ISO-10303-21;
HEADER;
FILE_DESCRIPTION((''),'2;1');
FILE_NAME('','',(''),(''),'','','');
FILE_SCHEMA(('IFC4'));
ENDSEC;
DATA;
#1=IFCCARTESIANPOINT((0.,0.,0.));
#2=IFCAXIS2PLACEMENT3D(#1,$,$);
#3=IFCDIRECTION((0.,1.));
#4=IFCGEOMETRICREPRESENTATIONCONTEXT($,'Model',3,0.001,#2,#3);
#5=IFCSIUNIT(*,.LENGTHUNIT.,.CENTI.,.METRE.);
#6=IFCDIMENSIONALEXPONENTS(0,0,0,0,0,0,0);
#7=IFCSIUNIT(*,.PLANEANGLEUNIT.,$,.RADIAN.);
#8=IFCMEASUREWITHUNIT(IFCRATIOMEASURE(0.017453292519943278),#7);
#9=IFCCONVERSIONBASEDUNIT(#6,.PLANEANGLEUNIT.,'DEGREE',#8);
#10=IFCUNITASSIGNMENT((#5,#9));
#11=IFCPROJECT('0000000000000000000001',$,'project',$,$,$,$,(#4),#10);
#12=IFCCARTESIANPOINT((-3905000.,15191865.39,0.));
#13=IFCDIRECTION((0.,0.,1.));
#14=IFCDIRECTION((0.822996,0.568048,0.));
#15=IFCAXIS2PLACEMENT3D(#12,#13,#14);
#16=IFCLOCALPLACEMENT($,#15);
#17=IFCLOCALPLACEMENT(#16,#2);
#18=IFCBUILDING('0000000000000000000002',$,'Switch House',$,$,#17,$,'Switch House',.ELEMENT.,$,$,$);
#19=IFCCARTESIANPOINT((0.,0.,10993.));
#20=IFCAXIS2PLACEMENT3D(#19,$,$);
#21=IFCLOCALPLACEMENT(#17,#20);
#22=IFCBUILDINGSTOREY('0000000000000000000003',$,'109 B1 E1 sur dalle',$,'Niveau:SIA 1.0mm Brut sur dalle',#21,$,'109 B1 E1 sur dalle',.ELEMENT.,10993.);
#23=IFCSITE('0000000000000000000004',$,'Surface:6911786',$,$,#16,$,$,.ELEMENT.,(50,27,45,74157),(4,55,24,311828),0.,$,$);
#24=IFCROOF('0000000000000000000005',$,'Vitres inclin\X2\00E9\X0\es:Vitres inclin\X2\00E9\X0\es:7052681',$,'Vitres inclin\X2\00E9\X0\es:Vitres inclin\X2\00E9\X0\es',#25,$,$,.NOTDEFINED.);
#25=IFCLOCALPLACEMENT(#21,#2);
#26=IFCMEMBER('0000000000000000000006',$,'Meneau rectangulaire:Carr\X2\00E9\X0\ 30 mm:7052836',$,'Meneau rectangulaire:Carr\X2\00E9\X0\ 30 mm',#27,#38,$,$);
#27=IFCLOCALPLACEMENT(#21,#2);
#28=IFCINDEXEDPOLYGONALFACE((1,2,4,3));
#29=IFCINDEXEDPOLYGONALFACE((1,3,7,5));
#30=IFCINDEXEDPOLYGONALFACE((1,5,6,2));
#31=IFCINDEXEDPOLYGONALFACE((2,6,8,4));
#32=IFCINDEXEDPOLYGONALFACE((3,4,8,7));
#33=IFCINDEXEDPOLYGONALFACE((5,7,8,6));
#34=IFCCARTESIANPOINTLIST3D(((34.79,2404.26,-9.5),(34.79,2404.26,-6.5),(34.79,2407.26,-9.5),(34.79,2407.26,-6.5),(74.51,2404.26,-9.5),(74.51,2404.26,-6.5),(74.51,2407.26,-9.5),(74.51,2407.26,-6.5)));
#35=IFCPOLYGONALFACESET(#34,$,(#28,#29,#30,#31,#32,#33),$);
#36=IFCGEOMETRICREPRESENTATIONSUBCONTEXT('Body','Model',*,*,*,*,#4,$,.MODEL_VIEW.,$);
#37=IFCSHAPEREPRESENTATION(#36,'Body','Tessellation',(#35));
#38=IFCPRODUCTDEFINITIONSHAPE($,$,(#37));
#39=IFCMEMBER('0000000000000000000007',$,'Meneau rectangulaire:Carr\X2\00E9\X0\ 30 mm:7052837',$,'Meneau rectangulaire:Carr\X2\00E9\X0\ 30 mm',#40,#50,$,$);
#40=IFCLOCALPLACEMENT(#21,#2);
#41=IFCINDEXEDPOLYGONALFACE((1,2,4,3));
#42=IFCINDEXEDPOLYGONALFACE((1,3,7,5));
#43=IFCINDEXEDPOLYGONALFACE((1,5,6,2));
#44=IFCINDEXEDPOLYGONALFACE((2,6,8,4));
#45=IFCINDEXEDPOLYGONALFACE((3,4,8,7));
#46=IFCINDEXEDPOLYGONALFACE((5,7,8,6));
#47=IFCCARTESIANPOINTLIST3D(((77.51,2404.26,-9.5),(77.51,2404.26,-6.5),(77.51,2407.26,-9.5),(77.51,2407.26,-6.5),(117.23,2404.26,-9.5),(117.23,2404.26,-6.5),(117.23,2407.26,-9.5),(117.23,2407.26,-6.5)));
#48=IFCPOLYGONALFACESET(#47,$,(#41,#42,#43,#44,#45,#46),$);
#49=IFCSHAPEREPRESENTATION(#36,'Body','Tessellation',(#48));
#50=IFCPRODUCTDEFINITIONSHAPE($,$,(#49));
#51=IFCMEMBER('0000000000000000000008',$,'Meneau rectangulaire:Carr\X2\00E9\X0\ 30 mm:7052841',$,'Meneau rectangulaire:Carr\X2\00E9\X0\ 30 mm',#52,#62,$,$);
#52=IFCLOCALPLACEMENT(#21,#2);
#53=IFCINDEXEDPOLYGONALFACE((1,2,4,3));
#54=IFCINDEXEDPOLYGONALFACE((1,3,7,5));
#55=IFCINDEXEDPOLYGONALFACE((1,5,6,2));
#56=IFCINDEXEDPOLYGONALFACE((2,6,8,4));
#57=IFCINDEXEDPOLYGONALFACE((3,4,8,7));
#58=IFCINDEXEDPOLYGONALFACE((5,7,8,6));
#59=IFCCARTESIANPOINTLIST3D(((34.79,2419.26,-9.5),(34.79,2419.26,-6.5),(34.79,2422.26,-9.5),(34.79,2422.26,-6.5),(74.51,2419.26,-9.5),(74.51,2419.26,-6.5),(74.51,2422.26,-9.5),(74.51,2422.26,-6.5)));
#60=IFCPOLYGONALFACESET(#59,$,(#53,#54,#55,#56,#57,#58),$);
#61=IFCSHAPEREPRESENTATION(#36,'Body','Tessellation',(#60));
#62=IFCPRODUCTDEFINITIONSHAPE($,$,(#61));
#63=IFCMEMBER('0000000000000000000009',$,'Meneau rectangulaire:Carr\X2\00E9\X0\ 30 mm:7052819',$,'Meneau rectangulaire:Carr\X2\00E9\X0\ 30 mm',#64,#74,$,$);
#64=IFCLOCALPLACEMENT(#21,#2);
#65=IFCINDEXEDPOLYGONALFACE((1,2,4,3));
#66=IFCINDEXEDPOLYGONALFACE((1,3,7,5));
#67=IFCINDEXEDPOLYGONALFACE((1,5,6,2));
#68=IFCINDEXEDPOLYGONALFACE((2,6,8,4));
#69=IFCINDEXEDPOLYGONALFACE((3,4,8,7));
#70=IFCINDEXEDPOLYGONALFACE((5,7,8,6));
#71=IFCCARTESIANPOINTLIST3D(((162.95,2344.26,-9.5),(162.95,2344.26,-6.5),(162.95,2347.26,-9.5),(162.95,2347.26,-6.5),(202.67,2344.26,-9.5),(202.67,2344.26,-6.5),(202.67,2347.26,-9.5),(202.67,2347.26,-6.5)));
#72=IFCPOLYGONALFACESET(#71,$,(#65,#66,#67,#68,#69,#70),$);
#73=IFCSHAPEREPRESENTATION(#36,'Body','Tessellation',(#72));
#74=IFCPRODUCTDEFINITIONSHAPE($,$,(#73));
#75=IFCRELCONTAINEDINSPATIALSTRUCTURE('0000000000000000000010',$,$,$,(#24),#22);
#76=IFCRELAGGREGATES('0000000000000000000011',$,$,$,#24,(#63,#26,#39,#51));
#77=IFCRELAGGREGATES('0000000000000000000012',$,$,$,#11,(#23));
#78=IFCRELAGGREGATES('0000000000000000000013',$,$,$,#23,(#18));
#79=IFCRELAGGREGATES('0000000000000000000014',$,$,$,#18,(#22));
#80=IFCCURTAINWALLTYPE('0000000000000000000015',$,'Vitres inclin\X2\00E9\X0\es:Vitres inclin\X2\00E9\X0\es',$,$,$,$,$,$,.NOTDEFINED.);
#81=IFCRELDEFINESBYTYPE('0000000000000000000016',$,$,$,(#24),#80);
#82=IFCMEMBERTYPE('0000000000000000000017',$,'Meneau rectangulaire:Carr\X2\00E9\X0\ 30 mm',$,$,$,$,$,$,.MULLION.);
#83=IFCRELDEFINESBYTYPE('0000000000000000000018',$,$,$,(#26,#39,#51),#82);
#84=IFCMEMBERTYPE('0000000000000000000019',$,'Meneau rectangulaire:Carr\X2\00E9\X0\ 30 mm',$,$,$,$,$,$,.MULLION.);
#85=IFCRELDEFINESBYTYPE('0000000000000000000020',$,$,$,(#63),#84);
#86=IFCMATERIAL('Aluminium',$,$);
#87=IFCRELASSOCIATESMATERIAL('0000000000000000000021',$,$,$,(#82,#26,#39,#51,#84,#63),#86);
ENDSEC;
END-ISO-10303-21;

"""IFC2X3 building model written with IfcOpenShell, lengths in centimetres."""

from ifc_helpers import new_model, entity, si_unit, converted_unit, direction, frame, origin, origin_2d_with_axis, place, context, subcontext, project, spatial, rectangle, extrude, source, transform, mapped, material, type_object, type_shapes, element, aggregate, save


model = new_model("IFC2X3")

# Units and contexts
model_context = context("Model", 3, precision=0.001, world=origin(), true_north=direction((0.0, 1.0)))
body_context = subcontext(model_context, "Body", "Model", "MODEL_VIEW")
ifc_project = project(units=[si_unit("LENGTHUNIT", "METRE", prefix="CENTI"), converted_unit("PLANEANGLEUNIT", "DEGREE", entity("IfcRatioMeasure", 0.017453292519943278), si_unit("PLANEANGLEUNIT", "RADIAN"), dimensions=[0, 0, 0, 0, 0, 0, 0])], contexts=[model_context])

# Site, building, storey
site_placement = place(None, frame((-3905000.0, 15191865.39, 0.0), z_axis=(0.0, 0.0, 1.0), x_axis=(0.822996, 0.568048, 0.0)))
site = spatial("IfcSite", under=ifc_project, at=site_placement, Name="Surface:6911786", CompositionType="ELEMENT", RefLatitude=(50, 27, 45, 74157), RefLongitude=(4, 55, 24, 311828), RefElevation=0.0)
building_placement = place(site_placement, origin())
building = spatial("IfcBuilding", under=site, at=building_placement, Name="Switch House", LongName="Switch House", CompositionType="ELEMENT")
storey_placement = place(building_placement, frame((0.0, 0.0, 10993.0)))
storey = spatial("IfcBuildingStorey", under=building, at=storey_placement, Name="109 B1 E1 sur dalle", ObjectType="Niveau:SIA 1.0mm Brut sur dalle", LongName="109 B1 E1 sur dalle", CompositionType="ELEMENT", Elevation=10993.0)

# Roof, members
curtain_wall_type = type_object("IfcCurtainWallType", Name="Vitres inclinées:Vitres inclinées", PredefinedType="NOTDEFINED")
roof_placement = place(storey_placement, frame((0.0, 0.0, -10993.0)))
roof = element("IfcRoof", 1, at=roof_placement, inside=storey, type_object=curtain_wall_type, Name="Vitres inclinées:Vitres inclinées:7052681", ObjectType="Vitres inclinées:Vitres inclinées", ShapeType="NOTDEFINED")
ifc_material = material(Name="Aluminium")
member_type_1 = type_object("IfcMemberType", Name="Meneau rectangulaire:Carré 30 mm", PredefinedType="MULLION", material=ifc_material)
shared_shape_1 = source(origin(), body_context, "Body", "SweptSolid", [
    extrude(rectangle(XDim=3.0, YDim=3.0, at=origin_2d_with_axis()), frame((0.0, 0.0, -39.72), z_axis=(0.0, 0.0, 1.0), x_axis=(0.0, -1.0, 0.0)), (0.0, 0.0, 1.0), 39.72),
])
type_shapes(member_type_1, [shared_shape_1])
member_1_placement = place(roof_placement, frame((34.79, 2405.76, 10985.0), z_axis=(-1.0, 0.0, 0.0), x_axis=(0.0, 1.0, 0.0)))
member_1 = element("IfcMember", 2, at=member_1_placement, type_object=member_type_1, material=ifc_material, Name="Meneau rectangulaire:Carré 30 mm:7052836", ObjectType="Meneau rectangulaire:Carré 30 mm", context=body_context, shape_type="MappedRepresentation", body=[
    mapped(shared_shape_1, transform((0.0, 0.0, 0.0), scale=1.0)),
])
member_2_placement = place(roof_placement, frame((77.51, 2405.76, 10985.0), z_axis=(-1.0, 0.0, 0.0), x_axis=(0.0, 1.0, 0.0)))
member_2 = element("IfcMember", 3, at=member_2_placement, type_object=member_type_1, material=ifc_material, Name="Meneau rectangulaire:Carré 30 mm:7052837", ObjectType="Meneau rectangulaire:Carré 30 mm", context=body_context, shape_type="MappedRepresentation", body=[
    mapped(shared_shape_1, transform((0.0, 0.0, 0.0), scale=1.0)),
])
member_3_placement = place(roof_placement, frame((34.79, 2420.76, 10985.0), z_axis=(-1.0, 0.0, 0.0), x_axis=(0.0, 1.0, 0.0)))
member_3 = element("IfcMember", 4, at=member_3_placement, type_object=member_type_1, material=ifc_material, Name="Meneau rectangulaire:Carré 30 mm:7052841", ObjectType="Meneau rectangulaire:Carré 30 mm", context=body_context, shape_type="MappedRepresentation", body=[
    mapped(shared_shape_1, transform((0.0, 0.0, 0.0), scale=1.0)),
])
member_type_2 = type_object("IfcMemberType", Name="Meneau rectangulaire:Carré 30 mm", PredefinedType="MULLION", material=ifc_material)
shared_shape_2 = source(origin(), body_context, "Body", "SweptSolid", [
    extrude(rectangle(XDim=3.0, YDim=3.0, at=origin_2d_with_axis()), frame((0.0, 0.0, -39.72), z_axis=(0.0, 0.0, 1.0), x_axis=(0.0, -1.0, 0.0)), (0.0, 0.0, 1.0), 39.72),
])
type_shapes(member_type_2, [shared_shape_2])
member_4_placement = place(roof_placement, frame((162.95, 2345.76, 10985.0), z_axis=(-1.0, 0.0, 0.0), x_axis=(0.0, 1.0, 0.0)))
member_4 = element("IfcMember", 5, at=member_4_placement, type_object=member_type_2, material=ifc_material, Name="Meneau rectangulaire:Carré 30 mm:7052819", ObjectType="Meneau rectangulaire:Carré 30 mm", context=body_context, shape_type="MappedRepresentation", body=[
    mapped(shared_shape_2, transform((0.0, 0.0, 0.0), scale=1.0)),
])
aggregate(roof, [member_4, member_1, member_2, member_3])

save(model, "model.ifc")
